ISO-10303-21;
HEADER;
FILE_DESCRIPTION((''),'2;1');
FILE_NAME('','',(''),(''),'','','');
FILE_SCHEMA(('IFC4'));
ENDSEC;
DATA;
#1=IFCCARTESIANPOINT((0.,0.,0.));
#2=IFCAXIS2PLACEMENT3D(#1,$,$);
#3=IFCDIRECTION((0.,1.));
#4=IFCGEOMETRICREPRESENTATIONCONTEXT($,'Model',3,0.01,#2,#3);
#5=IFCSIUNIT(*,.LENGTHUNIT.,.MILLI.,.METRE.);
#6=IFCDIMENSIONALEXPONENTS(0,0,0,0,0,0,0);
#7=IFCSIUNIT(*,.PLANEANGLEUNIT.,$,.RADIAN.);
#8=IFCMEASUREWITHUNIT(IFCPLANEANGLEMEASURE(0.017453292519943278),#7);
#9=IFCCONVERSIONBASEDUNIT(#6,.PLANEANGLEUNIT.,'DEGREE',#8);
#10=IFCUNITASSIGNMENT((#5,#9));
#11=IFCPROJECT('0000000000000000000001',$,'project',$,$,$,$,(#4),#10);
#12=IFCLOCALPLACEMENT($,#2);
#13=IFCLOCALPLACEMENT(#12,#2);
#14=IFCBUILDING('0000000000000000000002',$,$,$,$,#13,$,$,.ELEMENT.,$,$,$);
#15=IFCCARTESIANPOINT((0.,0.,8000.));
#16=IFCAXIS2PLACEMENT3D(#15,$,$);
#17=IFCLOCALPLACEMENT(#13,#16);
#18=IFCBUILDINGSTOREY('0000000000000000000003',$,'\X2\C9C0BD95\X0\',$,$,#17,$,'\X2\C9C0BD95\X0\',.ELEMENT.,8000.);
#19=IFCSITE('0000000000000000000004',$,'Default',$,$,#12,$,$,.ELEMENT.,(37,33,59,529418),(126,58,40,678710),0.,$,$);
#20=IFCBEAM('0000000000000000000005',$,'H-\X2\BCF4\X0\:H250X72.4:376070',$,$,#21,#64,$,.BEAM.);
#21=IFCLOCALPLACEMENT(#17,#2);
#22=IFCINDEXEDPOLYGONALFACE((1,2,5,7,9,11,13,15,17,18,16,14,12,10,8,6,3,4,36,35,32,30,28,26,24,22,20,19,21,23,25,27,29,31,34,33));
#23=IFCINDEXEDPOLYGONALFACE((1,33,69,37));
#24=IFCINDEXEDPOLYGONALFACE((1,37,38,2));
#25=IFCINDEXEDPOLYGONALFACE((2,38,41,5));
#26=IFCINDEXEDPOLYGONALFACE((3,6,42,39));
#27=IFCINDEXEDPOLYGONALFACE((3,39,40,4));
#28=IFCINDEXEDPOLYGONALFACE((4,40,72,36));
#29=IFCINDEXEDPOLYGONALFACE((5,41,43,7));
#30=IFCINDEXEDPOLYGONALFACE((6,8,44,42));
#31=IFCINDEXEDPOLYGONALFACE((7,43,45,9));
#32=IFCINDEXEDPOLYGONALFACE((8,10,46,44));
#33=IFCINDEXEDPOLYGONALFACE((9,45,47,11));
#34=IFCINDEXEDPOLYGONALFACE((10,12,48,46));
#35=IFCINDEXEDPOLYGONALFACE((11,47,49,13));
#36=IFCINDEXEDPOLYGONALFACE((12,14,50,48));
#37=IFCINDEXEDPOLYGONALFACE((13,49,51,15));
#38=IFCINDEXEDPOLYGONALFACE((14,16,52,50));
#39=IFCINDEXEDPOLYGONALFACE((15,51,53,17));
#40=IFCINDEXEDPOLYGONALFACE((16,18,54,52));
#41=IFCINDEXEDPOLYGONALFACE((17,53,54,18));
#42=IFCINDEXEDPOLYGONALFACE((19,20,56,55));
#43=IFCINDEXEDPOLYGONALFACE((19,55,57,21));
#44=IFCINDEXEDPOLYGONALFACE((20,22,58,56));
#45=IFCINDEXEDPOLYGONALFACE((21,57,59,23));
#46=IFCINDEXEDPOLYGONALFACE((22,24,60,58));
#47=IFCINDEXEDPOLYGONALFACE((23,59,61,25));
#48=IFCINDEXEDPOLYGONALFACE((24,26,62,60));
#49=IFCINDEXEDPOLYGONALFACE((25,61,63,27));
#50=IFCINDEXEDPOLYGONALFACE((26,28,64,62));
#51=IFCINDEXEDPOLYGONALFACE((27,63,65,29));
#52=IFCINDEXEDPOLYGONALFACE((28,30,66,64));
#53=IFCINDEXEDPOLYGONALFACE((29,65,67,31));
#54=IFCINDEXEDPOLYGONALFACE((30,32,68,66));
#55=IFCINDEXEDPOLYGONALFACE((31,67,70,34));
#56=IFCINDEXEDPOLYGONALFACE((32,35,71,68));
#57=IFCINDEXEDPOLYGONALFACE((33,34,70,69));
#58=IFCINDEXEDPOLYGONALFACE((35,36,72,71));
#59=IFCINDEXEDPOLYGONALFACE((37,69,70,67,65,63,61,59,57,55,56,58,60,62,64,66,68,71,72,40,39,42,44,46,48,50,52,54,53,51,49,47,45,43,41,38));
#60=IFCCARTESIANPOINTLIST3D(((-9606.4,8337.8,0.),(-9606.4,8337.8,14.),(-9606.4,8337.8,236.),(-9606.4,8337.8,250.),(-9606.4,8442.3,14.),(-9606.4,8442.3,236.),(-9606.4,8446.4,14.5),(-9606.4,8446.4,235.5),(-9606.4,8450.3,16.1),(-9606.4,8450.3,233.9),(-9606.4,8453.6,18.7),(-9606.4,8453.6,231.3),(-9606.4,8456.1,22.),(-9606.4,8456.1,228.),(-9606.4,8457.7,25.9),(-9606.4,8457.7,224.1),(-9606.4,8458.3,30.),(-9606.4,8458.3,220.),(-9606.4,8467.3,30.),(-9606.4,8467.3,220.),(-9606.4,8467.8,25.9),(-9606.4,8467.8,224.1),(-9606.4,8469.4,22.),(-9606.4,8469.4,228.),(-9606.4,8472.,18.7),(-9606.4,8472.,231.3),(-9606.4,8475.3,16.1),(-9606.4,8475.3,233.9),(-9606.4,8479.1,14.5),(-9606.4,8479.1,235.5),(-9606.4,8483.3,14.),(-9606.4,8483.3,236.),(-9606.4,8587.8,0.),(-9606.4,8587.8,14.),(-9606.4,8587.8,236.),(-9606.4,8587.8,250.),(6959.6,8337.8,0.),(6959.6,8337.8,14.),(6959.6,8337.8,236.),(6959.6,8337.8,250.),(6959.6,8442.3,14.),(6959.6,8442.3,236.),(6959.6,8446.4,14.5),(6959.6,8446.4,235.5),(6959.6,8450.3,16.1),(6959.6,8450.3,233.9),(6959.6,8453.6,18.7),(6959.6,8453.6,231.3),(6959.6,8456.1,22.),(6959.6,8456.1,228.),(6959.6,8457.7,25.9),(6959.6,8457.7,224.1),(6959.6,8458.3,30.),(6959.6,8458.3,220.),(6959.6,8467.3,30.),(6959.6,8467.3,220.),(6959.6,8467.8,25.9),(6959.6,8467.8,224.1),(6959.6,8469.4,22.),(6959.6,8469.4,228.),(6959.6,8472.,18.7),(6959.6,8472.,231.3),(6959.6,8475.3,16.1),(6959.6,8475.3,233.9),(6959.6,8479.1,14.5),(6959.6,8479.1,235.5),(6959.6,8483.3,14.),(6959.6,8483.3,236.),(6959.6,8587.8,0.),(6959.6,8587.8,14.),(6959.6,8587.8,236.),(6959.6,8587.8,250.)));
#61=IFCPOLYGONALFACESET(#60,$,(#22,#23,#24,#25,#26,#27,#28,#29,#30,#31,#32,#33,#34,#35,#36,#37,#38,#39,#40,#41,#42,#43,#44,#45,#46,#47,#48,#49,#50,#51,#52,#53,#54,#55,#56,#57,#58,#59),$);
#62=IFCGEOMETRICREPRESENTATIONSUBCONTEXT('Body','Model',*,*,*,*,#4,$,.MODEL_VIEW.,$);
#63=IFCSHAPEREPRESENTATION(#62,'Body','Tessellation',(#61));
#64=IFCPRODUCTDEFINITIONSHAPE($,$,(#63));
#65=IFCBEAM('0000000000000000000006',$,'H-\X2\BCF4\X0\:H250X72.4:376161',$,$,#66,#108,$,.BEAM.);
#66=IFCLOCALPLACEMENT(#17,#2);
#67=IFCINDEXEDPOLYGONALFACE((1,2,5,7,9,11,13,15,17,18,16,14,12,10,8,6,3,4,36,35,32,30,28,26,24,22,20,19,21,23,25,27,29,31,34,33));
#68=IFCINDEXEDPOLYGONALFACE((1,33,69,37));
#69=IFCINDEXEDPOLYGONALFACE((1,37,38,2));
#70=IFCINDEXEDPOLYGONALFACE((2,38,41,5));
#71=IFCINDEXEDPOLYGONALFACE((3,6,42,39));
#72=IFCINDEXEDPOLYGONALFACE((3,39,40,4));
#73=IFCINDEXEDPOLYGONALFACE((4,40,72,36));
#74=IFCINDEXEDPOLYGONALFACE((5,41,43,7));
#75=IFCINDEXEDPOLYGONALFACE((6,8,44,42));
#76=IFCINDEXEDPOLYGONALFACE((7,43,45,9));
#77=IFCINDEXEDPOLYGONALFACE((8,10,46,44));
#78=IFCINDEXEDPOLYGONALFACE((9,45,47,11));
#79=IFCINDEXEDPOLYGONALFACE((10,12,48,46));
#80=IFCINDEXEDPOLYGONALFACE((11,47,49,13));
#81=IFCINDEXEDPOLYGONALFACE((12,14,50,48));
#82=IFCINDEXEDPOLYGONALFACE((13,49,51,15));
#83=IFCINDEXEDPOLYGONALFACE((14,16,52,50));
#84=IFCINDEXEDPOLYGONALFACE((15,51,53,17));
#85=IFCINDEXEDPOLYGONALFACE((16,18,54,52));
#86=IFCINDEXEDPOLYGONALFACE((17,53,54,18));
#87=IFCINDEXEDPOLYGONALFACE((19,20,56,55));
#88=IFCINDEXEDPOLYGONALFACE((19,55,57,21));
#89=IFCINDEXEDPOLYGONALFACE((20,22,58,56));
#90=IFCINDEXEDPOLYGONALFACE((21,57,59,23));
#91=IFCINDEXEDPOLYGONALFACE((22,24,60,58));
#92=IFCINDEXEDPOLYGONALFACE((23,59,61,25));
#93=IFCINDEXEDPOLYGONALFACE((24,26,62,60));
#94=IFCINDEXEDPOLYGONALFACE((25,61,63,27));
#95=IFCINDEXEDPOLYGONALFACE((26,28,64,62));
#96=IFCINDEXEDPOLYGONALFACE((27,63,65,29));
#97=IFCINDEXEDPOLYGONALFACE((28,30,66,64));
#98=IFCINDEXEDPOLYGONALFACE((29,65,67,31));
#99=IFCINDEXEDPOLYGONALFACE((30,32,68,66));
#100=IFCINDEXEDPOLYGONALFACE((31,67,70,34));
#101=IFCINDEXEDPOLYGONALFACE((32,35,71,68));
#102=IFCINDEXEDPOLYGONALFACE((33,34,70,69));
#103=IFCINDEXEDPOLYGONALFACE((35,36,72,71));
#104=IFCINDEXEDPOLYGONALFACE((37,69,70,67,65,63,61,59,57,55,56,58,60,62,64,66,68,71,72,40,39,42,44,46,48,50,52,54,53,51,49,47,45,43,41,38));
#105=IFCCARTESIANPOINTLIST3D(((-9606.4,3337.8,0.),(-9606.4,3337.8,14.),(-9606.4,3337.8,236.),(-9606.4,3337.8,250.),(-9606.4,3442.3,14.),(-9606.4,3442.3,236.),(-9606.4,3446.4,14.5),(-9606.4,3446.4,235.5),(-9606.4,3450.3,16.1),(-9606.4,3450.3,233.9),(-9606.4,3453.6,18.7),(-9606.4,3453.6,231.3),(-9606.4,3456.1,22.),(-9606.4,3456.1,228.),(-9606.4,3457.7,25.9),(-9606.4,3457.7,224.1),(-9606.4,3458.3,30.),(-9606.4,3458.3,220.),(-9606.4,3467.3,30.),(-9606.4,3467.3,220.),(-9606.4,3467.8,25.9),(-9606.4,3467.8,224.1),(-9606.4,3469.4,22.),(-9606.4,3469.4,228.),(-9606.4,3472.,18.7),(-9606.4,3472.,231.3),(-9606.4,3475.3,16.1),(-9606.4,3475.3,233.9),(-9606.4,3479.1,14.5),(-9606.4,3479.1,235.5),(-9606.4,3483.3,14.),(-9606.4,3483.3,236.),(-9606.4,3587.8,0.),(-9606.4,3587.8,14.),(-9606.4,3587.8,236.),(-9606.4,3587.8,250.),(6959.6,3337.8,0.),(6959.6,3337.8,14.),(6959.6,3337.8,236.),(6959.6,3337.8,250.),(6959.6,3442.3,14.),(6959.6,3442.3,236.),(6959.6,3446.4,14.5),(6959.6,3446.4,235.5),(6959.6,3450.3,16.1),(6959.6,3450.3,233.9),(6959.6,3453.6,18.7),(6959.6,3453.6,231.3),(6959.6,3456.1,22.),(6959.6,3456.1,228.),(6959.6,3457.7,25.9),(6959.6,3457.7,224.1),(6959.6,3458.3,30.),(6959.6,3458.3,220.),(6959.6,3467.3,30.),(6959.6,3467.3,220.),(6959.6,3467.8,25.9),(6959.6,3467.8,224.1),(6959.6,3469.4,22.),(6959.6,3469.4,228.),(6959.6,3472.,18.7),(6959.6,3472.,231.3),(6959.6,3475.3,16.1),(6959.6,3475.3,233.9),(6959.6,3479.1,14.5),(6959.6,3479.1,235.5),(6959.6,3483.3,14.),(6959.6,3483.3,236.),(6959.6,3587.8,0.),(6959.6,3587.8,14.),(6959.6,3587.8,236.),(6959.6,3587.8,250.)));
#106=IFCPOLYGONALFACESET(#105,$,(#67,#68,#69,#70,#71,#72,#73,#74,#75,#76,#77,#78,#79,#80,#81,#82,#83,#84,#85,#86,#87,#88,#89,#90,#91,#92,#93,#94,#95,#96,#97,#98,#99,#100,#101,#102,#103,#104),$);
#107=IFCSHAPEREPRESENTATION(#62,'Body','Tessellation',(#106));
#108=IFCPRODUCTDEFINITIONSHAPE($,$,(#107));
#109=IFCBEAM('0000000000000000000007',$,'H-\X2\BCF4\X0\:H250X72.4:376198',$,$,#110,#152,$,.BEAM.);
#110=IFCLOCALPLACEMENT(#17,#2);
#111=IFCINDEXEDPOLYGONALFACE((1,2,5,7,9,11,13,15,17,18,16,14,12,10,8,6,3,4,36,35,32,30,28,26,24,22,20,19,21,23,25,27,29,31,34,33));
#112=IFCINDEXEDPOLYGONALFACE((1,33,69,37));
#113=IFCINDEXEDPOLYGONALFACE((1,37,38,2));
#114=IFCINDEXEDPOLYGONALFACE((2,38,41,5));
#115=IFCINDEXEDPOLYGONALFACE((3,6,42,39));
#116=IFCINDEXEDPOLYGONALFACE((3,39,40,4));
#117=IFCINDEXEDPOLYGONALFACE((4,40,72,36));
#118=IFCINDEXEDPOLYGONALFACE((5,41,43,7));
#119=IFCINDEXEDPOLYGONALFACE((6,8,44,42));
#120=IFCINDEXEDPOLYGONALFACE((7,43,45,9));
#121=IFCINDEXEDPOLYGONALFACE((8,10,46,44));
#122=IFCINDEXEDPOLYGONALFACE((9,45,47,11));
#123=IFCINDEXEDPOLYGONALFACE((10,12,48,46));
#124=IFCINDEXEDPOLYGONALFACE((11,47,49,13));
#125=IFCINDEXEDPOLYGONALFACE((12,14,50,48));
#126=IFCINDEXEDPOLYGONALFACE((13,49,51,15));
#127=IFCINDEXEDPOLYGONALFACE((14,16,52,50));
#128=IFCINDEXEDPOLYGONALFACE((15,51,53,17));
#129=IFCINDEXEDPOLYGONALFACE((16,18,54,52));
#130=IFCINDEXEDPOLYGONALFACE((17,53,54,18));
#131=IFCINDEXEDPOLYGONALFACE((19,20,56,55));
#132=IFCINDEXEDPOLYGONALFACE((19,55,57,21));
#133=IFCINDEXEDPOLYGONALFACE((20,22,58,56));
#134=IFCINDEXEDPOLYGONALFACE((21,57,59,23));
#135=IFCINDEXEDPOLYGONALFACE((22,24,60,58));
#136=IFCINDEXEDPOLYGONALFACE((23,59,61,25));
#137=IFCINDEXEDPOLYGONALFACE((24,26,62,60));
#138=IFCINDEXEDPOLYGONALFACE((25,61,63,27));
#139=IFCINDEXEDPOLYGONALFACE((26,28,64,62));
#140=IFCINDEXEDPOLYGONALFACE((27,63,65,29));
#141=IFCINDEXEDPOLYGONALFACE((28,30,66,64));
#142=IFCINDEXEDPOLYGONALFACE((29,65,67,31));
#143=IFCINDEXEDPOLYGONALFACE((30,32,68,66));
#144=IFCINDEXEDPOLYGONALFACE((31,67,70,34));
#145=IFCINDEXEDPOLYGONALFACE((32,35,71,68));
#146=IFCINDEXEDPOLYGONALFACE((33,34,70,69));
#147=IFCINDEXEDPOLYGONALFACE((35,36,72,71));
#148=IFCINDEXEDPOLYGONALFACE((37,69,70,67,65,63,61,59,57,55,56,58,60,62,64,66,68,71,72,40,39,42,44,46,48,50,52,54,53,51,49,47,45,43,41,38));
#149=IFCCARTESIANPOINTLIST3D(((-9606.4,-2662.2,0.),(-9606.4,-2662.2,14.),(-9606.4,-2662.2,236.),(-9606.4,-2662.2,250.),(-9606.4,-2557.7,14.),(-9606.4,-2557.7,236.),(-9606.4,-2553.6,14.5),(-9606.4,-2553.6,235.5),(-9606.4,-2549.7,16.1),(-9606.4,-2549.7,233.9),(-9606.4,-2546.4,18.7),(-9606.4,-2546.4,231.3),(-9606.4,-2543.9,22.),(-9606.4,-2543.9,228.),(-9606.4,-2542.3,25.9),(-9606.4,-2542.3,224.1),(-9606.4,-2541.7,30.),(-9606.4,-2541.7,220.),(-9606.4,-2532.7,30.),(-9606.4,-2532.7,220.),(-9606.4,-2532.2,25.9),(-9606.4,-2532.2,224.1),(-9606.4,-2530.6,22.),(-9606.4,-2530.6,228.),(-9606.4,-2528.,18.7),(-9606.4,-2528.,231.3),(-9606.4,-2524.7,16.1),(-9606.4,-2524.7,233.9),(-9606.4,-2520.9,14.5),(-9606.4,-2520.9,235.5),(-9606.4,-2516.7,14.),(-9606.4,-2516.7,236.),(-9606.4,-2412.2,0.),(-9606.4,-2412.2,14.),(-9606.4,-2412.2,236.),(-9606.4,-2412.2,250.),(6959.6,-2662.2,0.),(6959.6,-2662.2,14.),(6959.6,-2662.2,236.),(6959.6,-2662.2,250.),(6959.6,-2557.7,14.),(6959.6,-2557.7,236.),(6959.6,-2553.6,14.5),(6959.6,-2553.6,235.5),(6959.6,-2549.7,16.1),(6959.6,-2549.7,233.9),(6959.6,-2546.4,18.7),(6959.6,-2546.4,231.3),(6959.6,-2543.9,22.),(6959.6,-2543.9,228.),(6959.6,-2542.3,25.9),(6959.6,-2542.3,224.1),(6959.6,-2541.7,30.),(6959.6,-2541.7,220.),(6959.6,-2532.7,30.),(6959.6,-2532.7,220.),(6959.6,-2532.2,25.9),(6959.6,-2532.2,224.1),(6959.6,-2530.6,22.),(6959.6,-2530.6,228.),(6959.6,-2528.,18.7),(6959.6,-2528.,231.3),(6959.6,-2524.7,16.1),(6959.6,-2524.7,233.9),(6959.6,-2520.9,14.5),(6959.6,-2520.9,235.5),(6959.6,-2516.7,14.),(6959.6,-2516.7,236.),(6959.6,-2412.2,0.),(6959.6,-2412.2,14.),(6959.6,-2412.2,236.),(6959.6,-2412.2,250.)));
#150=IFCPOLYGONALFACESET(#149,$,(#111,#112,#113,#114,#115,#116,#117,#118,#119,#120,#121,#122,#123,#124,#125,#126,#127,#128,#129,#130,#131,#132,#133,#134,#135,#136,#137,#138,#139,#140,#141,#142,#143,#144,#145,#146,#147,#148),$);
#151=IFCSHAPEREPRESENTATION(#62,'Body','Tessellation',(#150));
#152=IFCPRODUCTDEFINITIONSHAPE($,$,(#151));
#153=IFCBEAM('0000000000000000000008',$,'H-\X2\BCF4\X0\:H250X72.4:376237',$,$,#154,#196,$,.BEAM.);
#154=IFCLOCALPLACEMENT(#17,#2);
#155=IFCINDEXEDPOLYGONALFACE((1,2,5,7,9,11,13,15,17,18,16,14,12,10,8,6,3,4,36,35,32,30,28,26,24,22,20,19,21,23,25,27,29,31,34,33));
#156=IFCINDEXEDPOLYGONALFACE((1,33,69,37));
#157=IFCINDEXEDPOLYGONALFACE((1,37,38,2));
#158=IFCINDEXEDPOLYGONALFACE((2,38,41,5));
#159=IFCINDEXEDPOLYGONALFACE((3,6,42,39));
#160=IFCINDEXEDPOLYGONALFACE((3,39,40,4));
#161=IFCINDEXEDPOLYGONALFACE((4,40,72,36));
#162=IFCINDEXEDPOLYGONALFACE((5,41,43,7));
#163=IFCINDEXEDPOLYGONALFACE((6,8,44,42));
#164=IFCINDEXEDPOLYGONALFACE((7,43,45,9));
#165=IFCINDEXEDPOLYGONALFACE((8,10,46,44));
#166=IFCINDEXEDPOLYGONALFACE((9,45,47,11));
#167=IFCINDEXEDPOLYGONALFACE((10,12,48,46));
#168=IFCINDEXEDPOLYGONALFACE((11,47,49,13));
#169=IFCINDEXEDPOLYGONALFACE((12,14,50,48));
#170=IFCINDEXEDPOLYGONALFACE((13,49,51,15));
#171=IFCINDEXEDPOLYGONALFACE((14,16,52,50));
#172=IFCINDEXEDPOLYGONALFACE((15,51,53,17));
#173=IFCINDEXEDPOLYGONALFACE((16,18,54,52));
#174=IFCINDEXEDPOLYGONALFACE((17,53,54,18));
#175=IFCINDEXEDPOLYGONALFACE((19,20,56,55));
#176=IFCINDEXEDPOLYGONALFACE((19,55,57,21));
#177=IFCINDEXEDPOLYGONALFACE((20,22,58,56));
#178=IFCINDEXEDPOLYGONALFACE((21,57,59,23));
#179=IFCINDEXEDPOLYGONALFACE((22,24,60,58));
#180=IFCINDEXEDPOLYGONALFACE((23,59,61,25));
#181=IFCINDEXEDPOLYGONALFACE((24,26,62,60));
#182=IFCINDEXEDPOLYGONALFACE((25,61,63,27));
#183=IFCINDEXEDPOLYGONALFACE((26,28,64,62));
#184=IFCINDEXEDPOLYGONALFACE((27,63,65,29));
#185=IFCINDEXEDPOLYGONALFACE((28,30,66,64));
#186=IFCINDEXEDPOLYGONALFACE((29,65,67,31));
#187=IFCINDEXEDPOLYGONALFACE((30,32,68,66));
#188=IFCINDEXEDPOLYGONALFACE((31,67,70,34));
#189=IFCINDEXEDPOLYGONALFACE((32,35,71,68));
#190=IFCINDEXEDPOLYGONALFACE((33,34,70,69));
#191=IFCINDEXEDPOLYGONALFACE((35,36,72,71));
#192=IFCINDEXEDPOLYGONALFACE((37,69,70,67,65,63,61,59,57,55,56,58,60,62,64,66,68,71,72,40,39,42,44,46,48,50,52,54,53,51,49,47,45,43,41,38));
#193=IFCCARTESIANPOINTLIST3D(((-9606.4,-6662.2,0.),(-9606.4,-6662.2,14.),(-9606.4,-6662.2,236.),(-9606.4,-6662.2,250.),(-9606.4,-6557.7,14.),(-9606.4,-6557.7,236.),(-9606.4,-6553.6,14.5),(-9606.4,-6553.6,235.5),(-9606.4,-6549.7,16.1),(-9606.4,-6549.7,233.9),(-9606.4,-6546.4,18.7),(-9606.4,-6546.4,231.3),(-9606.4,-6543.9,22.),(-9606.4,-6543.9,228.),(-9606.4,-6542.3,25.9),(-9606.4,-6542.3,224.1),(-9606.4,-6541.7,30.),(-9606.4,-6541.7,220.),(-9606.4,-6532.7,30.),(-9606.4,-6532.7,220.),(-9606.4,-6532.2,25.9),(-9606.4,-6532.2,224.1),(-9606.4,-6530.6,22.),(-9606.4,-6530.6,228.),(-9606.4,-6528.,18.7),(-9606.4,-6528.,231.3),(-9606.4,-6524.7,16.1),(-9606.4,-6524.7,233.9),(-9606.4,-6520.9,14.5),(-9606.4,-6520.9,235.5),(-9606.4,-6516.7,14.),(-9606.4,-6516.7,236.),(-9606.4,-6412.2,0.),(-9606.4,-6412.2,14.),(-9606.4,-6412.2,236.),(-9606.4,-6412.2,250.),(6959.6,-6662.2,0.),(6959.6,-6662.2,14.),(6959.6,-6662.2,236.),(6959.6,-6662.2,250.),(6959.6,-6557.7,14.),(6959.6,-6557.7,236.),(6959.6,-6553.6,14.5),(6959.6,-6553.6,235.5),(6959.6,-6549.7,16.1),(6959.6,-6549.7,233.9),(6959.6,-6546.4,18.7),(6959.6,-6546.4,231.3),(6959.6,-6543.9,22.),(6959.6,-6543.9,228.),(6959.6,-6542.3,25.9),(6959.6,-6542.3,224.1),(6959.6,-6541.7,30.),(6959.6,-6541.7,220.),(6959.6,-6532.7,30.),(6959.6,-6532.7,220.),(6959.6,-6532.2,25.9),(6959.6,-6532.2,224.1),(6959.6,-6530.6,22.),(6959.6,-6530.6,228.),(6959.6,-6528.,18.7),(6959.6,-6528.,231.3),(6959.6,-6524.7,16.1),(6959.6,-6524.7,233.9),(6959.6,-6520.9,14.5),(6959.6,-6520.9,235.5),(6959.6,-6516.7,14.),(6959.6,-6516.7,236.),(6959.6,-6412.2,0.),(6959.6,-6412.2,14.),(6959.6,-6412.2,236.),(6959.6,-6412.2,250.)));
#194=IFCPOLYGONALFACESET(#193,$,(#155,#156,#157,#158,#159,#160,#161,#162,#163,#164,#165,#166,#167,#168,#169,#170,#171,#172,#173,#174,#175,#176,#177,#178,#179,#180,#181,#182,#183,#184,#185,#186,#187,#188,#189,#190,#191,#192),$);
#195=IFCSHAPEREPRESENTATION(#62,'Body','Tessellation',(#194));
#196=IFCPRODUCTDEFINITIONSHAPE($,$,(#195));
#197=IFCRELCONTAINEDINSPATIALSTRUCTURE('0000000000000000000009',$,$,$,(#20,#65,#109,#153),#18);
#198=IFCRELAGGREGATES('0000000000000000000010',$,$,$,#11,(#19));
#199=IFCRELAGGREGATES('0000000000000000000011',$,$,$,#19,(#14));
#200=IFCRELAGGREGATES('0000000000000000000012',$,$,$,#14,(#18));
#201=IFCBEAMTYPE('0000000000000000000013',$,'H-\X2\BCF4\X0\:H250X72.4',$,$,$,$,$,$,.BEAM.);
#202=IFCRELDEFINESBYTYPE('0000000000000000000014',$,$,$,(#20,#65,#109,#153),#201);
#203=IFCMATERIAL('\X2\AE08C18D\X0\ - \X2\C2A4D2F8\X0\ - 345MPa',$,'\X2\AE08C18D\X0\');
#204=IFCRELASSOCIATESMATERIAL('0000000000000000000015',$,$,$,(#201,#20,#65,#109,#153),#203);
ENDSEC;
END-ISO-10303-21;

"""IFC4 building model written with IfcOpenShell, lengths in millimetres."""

from ifc_helpers import new_model, entity, si_unit, converted_unit, direction, frame, origin, place, context, subcontext, project, spatial, line, arc, indexed_curve, outline, extrude, source, transform, mapped, material, type_object, type_shapes, element, save


model = new_model("IFC4")

# Units and contexts
model_context = context("Model", 3, precision=0.01, world=origin(), true_north=direction((0.0, 1.0)))
body_context = subcontext(model_context, "Body", "Model", "MODEL_VIEW")
ifc_project = project(units=[si_unit("LENGTHUNIT", "METRE", prefix="MILLI"), converted_unit("PLANEANGLEUNIT", "DEGREE", entity("IfcPlaneAngleMeasure", 0.017453292519943278), si_unit("PLANEANGLEUNIT", "RADIAN"), dimensions=[0, 0, 0, 0, 0, 0, 0])], contexts=[model_context])

# Site, building, storey
site_placement = place(None, origin())
site = spatial("IfcSite", under=ifc_project, at=site_placement, Name="Default", CompositionType="ELEMENT", RefLatitude=(37, 33, 59, 529418), RefLongitude=(126, 58, 40, 678710), RefElevation=0.0)
building_placement = place(site_placement, origin())
building = spatial("IfcBuilding", under=site, at=building_placement, CompositionType="ELEMENT")
storey_placement = place(building_placement, frame((0.0, 0.0, 8000.0)))
storey = spatial("IfcBuildingStorey", under=building, at=storey_placement, Name="지붕", LongName="지붕", CompositionType="ELEMENT", Elevation=8000.0)

# Beams
ifc_material = material(Name="금속 - 스틸 - 345MPa", Category="금속")
beam_type_1 = type_object("IfcBeamType", Name="H-보:H250X72.4", PredefinedType="BEAM", material=ifc_material)
shared_shape_1 = source(origin(), body_context, "Body", "SweptSolid", [
    extrude(outline(indexed_curve([(-125.0, -111.0), (-125.0, -125.0), (125.0, -125.0), (125.0, -111.0), (20.5, -111.0), (9.2, -106.3), (4.5, -95.0), (4.5, 95.0), (9.2, 106.3), (20.5, 111.0), (125.0, 111.0), (125.0, 125.0), (-125.0, 125.0), (-125.0, 111.0), (-20.5, 111.0), (-9.2, 106.3), (-4.5, 95.0), (-4.5, -95.0), (-9.2, -106.3), (-20.5, -111.0)], segments=[line(1, 2, 3, 4, 5), arc(5, 6, 7), line(7, 8), arc(8, 9, 10), line(10, 11, 12, 13, 14, 15), arc(15, 16, 17), line(17, 18), arc(18, 19, 20), line(20, 1)], self_intersect=False)), frame((-8283.0, 0.0, 0.0), z_axis=(-1.0, 0.0, 0.0), x_axis=(0.0, -1.0, 0.0)), (0.0, 0.0, -1.0), 16566.0),
])
type_shapes(beam_type_1, [shared_shape_1])
for number, where, name in (
    (1, (-1323.4, 8462.8, 125.0), "H-보:H250X72.4:376070"),
    (2, (-1323.4, 3462.8, 125.0), "H-보:H250X72.4:376161"),
    (3, (-1323.4, -2537.2, 125.0), "H-보:H250X72.4:376198"),
    (4, (-1323.4, -6537.2, 125.0), "H-보:H250X72.4:376237"),
):
    element("IfcBeam", number, at=place(storey_placement, frame(where)), inside=storey, type_object=beam_type_1, material=ifc_material, Name=name, PredefinedType="BEAM", context=body_context, shape_type="MappedRepresentation", body=[
        mapped(shared_shape_1, transform((0.0, 0.0, 0.0), scale=1.0)),
    ])

save(model, "model.ifc")
